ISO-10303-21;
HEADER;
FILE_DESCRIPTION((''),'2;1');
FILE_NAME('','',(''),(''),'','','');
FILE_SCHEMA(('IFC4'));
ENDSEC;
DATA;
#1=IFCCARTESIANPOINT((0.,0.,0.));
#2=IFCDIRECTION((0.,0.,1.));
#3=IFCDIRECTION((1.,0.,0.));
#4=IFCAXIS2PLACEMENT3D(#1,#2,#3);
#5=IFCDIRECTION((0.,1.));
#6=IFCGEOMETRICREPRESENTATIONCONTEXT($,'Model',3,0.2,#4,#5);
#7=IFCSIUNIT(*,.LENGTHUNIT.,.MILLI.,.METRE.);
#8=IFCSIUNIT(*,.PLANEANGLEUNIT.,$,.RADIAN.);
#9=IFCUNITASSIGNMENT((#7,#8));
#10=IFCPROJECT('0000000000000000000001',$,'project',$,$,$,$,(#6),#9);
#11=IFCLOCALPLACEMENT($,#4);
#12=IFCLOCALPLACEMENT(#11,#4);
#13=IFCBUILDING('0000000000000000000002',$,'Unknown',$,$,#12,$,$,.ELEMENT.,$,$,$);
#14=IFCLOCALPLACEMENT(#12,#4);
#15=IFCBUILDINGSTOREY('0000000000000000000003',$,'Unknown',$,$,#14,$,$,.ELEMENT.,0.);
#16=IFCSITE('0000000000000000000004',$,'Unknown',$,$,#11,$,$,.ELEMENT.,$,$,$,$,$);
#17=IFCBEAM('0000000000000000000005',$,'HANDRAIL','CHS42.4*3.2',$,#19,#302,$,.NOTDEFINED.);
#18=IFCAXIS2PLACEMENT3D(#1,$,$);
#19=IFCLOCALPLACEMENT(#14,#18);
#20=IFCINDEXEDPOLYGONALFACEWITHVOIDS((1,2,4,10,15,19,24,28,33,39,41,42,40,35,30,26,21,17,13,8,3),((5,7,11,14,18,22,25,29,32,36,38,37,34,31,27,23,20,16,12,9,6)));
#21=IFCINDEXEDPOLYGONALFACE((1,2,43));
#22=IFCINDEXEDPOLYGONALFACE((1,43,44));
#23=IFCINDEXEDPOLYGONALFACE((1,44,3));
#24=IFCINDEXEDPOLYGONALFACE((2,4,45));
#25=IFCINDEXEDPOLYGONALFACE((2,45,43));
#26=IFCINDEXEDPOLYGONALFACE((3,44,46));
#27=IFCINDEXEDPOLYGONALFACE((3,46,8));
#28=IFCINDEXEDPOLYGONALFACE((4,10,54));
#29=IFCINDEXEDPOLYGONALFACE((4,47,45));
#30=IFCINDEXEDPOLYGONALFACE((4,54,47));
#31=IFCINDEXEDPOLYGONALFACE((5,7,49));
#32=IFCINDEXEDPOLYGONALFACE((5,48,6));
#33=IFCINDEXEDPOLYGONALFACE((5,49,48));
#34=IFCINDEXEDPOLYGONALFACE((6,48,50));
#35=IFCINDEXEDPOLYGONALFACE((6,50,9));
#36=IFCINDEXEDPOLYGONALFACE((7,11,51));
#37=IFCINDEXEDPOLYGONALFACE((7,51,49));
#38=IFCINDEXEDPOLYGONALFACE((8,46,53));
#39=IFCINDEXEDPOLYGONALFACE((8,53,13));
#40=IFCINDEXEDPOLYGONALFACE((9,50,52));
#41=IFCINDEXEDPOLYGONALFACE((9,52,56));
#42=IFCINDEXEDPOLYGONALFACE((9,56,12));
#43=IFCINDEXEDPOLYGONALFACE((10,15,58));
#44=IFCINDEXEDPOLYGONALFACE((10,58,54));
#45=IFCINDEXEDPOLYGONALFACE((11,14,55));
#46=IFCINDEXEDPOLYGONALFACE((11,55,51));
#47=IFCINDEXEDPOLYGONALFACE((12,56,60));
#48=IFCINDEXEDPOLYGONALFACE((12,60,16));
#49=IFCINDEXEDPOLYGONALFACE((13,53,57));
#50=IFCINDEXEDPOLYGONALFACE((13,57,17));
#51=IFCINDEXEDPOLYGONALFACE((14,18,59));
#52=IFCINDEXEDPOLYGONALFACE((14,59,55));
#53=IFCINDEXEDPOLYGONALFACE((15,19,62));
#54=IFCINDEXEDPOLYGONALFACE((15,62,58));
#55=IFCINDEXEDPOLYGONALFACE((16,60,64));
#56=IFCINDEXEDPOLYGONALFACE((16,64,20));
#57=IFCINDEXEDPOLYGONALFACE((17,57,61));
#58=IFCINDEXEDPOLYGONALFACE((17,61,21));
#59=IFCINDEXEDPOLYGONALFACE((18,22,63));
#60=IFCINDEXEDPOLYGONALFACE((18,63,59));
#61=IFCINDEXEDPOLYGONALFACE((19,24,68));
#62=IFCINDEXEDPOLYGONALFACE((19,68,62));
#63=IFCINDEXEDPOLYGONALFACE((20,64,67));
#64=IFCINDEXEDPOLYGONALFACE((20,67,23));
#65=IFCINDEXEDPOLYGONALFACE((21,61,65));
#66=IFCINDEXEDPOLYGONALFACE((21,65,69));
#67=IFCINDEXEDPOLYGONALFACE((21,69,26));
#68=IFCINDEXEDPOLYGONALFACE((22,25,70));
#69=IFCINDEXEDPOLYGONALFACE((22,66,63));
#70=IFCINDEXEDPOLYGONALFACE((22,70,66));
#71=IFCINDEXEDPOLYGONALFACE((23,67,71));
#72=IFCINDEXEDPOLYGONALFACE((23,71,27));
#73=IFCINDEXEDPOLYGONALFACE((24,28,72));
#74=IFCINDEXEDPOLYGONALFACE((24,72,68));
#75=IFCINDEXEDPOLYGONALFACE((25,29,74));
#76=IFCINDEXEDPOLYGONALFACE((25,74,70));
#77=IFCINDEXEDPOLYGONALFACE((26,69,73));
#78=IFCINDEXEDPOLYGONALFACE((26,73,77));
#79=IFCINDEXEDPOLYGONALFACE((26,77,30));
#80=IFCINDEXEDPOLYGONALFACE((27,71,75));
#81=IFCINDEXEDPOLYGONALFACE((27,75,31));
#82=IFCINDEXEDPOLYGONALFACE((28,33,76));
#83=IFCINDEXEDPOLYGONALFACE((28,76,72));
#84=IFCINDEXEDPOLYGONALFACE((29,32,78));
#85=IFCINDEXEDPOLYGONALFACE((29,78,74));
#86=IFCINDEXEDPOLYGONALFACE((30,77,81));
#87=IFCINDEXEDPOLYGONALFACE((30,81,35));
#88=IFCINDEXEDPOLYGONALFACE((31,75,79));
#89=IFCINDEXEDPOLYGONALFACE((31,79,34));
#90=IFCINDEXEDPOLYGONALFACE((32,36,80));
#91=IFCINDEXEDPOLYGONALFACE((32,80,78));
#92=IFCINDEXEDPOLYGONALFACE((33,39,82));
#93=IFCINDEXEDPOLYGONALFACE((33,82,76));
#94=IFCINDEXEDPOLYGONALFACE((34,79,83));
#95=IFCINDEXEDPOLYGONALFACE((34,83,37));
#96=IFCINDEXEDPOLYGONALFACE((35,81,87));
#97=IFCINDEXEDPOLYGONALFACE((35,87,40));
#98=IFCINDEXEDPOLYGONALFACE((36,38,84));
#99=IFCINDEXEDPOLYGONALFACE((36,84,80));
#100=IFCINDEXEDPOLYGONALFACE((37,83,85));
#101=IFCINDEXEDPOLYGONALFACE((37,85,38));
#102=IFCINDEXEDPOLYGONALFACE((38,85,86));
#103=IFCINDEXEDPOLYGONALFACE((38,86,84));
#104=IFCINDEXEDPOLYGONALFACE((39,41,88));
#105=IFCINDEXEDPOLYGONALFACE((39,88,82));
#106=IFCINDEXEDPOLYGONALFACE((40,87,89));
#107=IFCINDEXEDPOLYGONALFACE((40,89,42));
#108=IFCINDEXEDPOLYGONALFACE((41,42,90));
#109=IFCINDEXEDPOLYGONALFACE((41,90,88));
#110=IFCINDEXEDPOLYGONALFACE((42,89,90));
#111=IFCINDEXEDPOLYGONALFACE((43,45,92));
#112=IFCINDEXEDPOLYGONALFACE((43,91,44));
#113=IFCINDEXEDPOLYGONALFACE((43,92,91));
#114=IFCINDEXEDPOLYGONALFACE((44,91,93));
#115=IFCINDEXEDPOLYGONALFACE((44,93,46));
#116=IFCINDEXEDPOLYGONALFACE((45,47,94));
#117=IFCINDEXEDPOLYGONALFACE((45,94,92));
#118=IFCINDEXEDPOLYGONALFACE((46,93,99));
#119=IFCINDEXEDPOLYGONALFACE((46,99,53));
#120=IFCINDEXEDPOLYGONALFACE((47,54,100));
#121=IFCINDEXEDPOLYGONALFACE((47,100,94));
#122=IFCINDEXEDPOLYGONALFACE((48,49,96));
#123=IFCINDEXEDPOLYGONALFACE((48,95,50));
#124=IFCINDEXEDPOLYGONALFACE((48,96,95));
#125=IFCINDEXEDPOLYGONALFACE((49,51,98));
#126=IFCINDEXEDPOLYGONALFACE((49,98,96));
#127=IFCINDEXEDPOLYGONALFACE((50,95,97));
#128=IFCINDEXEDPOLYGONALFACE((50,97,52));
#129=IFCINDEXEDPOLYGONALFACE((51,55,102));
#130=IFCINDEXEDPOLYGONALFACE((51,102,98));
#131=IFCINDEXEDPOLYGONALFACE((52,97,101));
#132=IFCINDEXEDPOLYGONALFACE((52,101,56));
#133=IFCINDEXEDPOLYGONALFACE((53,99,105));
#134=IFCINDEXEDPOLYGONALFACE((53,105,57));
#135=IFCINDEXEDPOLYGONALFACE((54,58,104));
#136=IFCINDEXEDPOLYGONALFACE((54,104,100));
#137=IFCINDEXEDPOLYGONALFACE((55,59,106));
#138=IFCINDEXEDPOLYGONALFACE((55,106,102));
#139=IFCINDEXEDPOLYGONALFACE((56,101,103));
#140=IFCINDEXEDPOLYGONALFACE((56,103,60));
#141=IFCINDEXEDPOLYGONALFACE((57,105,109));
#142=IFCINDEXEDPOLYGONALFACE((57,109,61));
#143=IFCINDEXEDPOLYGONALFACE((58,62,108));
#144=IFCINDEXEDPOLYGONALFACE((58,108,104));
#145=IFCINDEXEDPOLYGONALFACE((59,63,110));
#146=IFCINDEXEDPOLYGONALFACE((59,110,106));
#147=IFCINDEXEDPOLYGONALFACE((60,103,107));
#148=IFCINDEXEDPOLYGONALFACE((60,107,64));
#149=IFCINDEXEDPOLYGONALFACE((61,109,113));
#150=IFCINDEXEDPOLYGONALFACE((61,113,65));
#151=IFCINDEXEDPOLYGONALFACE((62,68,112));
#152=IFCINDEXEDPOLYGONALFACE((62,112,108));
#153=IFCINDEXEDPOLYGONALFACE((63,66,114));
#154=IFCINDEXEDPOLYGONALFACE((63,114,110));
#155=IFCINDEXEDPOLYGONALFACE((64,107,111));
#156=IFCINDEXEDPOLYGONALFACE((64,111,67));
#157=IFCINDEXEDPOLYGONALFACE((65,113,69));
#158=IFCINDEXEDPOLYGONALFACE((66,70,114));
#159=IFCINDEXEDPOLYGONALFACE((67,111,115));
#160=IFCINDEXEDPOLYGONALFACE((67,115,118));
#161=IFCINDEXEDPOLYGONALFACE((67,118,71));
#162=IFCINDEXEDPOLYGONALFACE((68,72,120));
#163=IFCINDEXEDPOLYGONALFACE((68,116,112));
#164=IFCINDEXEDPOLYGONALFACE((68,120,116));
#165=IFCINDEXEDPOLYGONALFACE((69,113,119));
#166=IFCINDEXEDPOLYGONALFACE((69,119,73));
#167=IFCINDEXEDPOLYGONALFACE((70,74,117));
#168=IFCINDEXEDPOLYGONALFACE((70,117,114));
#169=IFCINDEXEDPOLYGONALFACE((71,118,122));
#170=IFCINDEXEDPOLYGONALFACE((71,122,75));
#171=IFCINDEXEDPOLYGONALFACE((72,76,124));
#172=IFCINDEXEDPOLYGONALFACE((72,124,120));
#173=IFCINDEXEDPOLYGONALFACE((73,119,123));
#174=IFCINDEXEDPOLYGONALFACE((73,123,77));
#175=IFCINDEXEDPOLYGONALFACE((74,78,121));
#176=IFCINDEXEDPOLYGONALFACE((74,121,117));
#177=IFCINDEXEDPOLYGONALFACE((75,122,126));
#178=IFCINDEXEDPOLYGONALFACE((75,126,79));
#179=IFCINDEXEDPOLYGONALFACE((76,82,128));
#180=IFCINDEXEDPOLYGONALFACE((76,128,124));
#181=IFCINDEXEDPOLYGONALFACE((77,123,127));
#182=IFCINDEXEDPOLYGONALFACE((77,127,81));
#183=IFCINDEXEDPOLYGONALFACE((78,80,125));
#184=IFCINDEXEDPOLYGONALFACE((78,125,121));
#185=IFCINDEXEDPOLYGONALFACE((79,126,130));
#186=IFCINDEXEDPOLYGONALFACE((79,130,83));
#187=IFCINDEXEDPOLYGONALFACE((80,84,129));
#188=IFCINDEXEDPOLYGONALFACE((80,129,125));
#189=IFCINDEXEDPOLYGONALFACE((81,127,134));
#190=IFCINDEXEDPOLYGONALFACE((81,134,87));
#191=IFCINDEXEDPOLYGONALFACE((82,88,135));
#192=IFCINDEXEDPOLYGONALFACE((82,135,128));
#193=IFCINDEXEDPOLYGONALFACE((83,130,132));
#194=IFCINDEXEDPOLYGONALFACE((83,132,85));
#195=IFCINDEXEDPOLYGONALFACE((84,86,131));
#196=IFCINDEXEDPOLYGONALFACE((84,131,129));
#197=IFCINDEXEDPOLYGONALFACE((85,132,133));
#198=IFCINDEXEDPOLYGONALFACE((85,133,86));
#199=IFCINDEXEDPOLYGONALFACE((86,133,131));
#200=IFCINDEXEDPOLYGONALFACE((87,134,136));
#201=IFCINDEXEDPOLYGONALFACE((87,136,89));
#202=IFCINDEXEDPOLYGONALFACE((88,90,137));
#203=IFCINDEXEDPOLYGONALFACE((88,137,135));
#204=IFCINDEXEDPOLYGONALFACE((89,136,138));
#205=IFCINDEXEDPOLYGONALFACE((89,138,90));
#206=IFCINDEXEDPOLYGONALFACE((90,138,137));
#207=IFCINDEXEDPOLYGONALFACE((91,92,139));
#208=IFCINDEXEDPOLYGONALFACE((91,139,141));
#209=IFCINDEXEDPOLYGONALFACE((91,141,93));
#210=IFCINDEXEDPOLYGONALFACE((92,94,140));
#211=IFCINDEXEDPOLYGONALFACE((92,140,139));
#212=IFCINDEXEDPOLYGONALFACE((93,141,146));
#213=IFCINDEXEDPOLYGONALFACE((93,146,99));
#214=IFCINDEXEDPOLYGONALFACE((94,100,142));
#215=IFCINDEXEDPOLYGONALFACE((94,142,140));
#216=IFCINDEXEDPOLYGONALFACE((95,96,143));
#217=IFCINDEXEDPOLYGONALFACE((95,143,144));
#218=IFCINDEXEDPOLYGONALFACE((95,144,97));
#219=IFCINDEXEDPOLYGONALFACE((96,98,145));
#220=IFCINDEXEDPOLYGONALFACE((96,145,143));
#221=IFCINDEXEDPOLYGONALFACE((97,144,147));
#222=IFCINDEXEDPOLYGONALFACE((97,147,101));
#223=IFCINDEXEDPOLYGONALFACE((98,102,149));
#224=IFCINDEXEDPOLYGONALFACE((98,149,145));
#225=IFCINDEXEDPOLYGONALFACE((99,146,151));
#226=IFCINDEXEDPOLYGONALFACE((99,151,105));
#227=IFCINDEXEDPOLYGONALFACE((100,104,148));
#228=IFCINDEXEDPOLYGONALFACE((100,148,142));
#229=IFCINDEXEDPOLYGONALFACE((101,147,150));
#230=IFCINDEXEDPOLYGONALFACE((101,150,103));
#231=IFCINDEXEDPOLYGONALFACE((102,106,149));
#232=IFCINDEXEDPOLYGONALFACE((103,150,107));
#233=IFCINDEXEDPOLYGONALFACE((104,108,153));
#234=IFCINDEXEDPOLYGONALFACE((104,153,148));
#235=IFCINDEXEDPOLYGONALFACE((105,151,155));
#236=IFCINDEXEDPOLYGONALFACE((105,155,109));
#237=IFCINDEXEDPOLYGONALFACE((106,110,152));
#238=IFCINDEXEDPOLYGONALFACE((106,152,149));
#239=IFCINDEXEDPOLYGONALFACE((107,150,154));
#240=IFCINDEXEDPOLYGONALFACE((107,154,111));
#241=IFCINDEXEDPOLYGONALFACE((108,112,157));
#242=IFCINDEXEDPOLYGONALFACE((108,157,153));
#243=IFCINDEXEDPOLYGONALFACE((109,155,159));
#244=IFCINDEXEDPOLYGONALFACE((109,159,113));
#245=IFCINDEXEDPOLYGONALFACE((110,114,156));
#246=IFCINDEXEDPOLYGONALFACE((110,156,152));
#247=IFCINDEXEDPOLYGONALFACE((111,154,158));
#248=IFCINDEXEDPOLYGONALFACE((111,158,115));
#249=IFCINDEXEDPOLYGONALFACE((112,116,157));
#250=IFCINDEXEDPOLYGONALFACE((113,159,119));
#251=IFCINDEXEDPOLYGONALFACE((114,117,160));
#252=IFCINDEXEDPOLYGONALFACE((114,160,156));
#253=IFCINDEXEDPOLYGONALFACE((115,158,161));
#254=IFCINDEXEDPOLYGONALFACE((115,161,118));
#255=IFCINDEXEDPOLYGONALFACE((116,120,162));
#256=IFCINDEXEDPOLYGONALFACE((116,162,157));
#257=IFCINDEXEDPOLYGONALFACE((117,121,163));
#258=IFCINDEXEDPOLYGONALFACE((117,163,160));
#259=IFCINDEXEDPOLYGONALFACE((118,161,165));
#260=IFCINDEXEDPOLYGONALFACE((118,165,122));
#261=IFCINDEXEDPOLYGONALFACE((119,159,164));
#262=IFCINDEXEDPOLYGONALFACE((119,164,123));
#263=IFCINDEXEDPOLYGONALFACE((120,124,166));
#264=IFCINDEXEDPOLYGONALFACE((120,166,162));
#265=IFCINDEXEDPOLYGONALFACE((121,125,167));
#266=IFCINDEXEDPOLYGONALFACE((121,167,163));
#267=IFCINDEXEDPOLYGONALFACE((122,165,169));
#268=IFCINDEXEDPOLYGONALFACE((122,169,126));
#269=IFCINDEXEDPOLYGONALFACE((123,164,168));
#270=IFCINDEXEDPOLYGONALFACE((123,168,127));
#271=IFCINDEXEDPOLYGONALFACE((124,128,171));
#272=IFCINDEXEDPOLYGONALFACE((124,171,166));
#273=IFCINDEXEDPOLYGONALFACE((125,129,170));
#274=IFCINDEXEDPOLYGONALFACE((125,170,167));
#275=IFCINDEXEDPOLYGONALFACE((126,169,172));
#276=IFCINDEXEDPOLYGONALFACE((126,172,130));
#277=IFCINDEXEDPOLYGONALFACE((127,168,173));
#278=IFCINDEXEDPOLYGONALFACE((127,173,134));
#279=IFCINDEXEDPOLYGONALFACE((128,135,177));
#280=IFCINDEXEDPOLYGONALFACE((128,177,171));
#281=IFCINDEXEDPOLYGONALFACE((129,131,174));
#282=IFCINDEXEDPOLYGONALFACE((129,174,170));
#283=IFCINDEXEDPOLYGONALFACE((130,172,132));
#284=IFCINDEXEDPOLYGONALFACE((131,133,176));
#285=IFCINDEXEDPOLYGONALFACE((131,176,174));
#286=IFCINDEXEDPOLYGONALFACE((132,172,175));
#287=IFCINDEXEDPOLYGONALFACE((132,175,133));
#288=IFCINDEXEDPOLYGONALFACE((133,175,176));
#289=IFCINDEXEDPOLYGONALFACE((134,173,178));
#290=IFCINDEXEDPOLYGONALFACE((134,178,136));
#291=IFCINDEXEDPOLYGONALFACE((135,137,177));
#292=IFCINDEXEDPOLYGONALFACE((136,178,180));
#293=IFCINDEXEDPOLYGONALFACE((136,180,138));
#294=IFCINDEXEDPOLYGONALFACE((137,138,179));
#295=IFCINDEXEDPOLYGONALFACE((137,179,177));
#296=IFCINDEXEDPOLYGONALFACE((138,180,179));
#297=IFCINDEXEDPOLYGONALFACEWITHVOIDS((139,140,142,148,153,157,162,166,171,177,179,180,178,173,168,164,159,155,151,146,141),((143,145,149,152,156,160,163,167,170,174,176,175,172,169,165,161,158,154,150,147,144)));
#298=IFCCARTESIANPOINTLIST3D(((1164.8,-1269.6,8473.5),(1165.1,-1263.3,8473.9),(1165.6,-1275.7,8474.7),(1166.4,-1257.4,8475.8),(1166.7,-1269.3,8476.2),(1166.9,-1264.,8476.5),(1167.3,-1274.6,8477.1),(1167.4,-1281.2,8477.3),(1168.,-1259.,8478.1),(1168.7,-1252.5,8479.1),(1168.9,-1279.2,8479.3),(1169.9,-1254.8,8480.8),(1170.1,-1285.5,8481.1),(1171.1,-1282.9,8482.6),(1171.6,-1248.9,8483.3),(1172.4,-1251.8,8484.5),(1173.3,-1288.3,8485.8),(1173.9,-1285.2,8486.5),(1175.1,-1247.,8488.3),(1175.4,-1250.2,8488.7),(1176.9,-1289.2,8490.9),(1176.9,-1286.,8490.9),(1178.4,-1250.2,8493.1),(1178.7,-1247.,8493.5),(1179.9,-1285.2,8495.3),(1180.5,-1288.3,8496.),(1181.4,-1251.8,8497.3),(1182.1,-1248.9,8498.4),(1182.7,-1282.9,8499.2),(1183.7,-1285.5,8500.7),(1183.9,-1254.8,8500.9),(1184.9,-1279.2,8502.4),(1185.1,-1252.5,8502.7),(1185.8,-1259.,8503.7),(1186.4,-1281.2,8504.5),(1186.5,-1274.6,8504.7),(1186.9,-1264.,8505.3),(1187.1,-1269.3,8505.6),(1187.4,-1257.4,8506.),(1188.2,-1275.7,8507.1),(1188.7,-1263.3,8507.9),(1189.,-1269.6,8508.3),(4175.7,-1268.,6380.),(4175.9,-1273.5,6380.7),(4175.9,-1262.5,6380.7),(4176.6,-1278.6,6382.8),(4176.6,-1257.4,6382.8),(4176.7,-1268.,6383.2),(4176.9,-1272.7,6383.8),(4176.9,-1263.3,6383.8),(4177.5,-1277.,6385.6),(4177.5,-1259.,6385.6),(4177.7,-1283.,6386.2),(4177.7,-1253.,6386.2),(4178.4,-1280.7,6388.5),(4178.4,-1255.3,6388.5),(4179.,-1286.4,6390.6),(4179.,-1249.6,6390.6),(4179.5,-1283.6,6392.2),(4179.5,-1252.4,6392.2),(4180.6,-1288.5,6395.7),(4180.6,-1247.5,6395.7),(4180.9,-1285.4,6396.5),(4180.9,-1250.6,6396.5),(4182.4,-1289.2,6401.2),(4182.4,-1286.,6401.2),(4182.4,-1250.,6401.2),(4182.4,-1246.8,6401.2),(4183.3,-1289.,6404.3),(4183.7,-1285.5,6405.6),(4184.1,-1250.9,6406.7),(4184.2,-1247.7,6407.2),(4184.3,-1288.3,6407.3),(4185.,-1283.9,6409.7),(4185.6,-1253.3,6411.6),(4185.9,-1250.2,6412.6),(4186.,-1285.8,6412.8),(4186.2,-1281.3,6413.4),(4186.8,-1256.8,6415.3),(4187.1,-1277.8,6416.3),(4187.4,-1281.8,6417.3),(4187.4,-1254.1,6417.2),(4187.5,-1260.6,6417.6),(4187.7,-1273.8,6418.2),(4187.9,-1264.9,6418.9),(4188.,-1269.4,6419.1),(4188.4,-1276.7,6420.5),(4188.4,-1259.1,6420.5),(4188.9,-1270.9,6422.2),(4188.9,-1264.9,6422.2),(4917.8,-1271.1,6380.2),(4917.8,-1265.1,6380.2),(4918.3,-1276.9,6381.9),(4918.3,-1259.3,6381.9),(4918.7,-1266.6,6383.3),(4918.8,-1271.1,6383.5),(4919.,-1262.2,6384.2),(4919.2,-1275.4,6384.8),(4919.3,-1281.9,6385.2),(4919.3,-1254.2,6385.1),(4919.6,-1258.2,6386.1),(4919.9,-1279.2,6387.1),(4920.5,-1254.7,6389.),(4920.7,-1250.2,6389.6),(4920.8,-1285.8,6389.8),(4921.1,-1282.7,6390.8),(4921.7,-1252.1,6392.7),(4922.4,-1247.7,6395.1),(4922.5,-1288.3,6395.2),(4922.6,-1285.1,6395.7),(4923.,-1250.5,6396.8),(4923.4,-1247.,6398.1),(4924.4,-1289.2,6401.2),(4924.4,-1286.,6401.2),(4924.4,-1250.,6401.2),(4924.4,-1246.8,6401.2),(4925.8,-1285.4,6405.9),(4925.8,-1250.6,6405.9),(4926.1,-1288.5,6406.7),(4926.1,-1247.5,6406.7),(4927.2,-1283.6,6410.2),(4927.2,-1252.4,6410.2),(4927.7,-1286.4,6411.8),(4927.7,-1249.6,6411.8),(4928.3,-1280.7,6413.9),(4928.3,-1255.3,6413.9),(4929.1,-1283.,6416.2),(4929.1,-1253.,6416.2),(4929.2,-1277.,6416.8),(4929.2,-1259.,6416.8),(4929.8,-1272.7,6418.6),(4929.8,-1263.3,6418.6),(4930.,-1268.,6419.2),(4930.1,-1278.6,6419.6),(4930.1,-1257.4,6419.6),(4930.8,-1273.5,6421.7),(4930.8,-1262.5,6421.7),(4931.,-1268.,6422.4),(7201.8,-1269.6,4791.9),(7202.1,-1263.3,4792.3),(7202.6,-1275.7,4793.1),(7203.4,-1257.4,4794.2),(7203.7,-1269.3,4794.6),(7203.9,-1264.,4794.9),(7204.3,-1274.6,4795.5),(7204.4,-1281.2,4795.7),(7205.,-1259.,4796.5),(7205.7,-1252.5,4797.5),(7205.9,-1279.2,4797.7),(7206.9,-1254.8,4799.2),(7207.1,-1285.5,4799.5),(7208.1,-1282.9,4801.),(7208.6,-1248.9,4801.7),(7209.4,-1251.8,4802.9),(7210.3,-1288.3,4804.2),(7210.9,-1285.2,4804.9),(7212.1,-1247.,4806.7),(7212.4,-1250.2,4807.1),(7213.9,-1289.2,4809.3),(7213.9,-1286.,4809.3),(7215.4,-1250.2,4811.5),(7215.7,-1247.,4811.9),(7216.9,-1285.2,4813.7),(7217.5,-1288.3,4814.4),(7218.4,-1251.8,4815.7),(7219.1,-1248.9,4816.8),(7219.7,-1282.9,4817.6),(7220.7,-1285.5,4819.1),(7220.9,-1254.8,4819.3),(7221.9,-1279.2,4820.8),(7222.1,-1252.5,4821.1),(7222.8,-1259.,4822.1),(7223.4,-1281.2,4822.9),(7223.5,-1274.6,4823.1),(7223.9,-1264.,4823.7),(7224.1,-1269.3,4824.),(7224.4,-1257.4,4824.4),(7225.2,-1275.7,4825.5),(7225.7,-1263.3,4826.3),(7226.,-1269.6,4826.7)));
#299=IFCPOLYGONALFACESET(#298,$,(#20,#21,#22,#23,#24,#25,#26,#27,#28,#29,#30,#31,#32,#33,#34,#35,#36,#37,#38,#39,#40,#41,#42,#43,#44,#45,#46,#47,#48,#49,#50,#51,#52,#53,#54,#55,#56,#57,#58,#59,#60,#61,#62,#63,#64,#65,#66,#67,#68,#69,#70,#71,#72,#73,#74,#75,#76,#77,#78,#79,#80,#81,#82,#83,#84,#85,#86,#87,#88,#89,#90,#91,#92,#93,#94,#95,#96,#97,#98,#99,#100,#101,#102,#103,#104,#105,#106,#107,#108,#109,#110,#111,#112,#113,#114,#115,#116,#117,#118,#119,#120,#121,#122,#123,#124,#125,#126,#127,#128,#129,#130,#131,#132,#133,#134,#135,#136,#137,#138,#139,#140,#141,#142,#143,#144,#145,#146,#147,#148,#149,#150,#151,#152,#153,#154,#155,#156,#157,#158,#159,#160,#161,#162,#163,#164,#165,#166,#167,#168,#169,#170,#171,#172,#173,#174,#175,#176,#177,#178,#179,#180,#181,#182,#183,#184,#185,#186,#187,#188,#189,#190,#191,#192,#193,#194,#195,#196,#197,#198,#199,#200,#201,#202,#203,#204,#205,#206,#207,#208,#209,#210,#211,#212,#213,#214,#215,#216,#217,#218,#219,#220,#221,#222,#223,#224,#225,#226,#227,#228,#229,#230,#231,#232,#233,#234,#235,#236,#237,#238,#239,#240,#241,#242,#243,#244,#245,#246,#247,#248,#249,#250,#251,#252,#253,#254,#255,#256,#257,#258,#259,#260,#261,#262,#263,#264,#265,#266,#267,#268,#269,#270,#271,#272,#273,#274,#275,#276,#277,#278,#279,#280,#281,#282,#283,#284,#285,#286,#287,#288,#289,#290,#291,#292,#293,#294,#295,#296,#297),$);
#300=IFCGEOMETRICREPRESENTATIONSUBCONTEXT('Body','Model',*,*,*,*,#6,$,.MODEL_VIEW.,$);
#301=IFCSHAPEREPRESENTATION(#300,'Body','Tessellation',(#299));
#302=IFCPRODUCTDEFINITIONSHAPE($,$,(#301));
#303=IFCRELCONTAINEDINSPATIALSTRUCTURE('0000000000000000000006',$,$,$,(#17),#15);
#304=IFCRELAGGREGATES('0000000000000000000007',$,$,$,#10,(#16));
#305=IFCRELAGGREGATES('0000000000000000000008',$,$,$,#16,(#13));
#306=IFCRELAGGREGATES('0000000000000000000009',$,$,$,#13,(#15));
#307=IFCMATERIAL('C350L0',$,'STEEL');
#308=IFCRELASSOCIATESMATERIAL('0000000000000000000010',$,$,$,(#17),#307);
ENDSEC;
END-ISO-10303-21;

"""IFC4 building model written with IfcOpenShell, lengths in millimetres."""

from ifc_helpers import new_model, entity, si_unit, direction, frame, origin_with_axes, place, context, subcontext, project, spatial, material, element, save


model = new_model("IFC4")

# Units and contexts
model_context = context("Model", 3, precision=0.2, world=origin_with_axes(), true_north=direction((0.0, 1.0)))
body_context = subcontext(model_context, "Body", "Model", "MODEL_VIEW")
ifc_project = project(units=[si_unit("LENGTHUNIT", "METRE", prefix="MILLI"), si_unit("PLANEANGLEUNIT", "RADIAN")], contexts=[model_context])

# Site, building, storey
site_placement = place(None, origin_with_axes())
site = spatial("IfcSite", under=ifc_project, at=site_placement, Name="Unknown", CompositionType="ELEMENT")
building_placement = place(site_placement, origin_with_axes())
building = spatial("IfcBuilding", under=site, at=building_placement, Name="Unknown", CompositionType="ELEMENT")
storey_placement = place(building_placement, origin_with_axes())
storey = spatial("IfcBuildingStorey", under=building, at=storey_placement, Name="Unknown", CompositionType="ELEMENT", Elevation=0.0)

# Shared definitions
ifc_material_1 = material(Name="C350L0", Category="STEEL")

# Beam
for number, where, z_axis, x_axis, name in (
    (1, (1176.9, -1268.0, 8490.9), (0.0, -1.0, 0.0), (0.821041, 0.0, -0.57087), "HANDRAIL"),
):
    element("IfcBeam", number, at=place(storey_placement, frame(where, z_axis=z_axis, x_axis=x_axis)), inside=storey, material=ifc_material_1, Name=name, Description="CHS42.4*3.2", PredefinedType="NOTDEFINED", context=body_context, shape_type="SolidModel", body=[
        entity("IfcSweptDiskSolid", entity("IfcIndexedPolyCurve", entity("IfcCartesianPointList3D", [[0.0, 0.0, 0.0], [3660.5, 0.0, 0.0], [4269.8, 423.6, 0.0], [7058.3, 423.6, 0.0]]), [entity("IfcLineIndex", [1, 2, 3, 4])]), 21.2, 18.0),
    ])

save(model, "model.ifc")
